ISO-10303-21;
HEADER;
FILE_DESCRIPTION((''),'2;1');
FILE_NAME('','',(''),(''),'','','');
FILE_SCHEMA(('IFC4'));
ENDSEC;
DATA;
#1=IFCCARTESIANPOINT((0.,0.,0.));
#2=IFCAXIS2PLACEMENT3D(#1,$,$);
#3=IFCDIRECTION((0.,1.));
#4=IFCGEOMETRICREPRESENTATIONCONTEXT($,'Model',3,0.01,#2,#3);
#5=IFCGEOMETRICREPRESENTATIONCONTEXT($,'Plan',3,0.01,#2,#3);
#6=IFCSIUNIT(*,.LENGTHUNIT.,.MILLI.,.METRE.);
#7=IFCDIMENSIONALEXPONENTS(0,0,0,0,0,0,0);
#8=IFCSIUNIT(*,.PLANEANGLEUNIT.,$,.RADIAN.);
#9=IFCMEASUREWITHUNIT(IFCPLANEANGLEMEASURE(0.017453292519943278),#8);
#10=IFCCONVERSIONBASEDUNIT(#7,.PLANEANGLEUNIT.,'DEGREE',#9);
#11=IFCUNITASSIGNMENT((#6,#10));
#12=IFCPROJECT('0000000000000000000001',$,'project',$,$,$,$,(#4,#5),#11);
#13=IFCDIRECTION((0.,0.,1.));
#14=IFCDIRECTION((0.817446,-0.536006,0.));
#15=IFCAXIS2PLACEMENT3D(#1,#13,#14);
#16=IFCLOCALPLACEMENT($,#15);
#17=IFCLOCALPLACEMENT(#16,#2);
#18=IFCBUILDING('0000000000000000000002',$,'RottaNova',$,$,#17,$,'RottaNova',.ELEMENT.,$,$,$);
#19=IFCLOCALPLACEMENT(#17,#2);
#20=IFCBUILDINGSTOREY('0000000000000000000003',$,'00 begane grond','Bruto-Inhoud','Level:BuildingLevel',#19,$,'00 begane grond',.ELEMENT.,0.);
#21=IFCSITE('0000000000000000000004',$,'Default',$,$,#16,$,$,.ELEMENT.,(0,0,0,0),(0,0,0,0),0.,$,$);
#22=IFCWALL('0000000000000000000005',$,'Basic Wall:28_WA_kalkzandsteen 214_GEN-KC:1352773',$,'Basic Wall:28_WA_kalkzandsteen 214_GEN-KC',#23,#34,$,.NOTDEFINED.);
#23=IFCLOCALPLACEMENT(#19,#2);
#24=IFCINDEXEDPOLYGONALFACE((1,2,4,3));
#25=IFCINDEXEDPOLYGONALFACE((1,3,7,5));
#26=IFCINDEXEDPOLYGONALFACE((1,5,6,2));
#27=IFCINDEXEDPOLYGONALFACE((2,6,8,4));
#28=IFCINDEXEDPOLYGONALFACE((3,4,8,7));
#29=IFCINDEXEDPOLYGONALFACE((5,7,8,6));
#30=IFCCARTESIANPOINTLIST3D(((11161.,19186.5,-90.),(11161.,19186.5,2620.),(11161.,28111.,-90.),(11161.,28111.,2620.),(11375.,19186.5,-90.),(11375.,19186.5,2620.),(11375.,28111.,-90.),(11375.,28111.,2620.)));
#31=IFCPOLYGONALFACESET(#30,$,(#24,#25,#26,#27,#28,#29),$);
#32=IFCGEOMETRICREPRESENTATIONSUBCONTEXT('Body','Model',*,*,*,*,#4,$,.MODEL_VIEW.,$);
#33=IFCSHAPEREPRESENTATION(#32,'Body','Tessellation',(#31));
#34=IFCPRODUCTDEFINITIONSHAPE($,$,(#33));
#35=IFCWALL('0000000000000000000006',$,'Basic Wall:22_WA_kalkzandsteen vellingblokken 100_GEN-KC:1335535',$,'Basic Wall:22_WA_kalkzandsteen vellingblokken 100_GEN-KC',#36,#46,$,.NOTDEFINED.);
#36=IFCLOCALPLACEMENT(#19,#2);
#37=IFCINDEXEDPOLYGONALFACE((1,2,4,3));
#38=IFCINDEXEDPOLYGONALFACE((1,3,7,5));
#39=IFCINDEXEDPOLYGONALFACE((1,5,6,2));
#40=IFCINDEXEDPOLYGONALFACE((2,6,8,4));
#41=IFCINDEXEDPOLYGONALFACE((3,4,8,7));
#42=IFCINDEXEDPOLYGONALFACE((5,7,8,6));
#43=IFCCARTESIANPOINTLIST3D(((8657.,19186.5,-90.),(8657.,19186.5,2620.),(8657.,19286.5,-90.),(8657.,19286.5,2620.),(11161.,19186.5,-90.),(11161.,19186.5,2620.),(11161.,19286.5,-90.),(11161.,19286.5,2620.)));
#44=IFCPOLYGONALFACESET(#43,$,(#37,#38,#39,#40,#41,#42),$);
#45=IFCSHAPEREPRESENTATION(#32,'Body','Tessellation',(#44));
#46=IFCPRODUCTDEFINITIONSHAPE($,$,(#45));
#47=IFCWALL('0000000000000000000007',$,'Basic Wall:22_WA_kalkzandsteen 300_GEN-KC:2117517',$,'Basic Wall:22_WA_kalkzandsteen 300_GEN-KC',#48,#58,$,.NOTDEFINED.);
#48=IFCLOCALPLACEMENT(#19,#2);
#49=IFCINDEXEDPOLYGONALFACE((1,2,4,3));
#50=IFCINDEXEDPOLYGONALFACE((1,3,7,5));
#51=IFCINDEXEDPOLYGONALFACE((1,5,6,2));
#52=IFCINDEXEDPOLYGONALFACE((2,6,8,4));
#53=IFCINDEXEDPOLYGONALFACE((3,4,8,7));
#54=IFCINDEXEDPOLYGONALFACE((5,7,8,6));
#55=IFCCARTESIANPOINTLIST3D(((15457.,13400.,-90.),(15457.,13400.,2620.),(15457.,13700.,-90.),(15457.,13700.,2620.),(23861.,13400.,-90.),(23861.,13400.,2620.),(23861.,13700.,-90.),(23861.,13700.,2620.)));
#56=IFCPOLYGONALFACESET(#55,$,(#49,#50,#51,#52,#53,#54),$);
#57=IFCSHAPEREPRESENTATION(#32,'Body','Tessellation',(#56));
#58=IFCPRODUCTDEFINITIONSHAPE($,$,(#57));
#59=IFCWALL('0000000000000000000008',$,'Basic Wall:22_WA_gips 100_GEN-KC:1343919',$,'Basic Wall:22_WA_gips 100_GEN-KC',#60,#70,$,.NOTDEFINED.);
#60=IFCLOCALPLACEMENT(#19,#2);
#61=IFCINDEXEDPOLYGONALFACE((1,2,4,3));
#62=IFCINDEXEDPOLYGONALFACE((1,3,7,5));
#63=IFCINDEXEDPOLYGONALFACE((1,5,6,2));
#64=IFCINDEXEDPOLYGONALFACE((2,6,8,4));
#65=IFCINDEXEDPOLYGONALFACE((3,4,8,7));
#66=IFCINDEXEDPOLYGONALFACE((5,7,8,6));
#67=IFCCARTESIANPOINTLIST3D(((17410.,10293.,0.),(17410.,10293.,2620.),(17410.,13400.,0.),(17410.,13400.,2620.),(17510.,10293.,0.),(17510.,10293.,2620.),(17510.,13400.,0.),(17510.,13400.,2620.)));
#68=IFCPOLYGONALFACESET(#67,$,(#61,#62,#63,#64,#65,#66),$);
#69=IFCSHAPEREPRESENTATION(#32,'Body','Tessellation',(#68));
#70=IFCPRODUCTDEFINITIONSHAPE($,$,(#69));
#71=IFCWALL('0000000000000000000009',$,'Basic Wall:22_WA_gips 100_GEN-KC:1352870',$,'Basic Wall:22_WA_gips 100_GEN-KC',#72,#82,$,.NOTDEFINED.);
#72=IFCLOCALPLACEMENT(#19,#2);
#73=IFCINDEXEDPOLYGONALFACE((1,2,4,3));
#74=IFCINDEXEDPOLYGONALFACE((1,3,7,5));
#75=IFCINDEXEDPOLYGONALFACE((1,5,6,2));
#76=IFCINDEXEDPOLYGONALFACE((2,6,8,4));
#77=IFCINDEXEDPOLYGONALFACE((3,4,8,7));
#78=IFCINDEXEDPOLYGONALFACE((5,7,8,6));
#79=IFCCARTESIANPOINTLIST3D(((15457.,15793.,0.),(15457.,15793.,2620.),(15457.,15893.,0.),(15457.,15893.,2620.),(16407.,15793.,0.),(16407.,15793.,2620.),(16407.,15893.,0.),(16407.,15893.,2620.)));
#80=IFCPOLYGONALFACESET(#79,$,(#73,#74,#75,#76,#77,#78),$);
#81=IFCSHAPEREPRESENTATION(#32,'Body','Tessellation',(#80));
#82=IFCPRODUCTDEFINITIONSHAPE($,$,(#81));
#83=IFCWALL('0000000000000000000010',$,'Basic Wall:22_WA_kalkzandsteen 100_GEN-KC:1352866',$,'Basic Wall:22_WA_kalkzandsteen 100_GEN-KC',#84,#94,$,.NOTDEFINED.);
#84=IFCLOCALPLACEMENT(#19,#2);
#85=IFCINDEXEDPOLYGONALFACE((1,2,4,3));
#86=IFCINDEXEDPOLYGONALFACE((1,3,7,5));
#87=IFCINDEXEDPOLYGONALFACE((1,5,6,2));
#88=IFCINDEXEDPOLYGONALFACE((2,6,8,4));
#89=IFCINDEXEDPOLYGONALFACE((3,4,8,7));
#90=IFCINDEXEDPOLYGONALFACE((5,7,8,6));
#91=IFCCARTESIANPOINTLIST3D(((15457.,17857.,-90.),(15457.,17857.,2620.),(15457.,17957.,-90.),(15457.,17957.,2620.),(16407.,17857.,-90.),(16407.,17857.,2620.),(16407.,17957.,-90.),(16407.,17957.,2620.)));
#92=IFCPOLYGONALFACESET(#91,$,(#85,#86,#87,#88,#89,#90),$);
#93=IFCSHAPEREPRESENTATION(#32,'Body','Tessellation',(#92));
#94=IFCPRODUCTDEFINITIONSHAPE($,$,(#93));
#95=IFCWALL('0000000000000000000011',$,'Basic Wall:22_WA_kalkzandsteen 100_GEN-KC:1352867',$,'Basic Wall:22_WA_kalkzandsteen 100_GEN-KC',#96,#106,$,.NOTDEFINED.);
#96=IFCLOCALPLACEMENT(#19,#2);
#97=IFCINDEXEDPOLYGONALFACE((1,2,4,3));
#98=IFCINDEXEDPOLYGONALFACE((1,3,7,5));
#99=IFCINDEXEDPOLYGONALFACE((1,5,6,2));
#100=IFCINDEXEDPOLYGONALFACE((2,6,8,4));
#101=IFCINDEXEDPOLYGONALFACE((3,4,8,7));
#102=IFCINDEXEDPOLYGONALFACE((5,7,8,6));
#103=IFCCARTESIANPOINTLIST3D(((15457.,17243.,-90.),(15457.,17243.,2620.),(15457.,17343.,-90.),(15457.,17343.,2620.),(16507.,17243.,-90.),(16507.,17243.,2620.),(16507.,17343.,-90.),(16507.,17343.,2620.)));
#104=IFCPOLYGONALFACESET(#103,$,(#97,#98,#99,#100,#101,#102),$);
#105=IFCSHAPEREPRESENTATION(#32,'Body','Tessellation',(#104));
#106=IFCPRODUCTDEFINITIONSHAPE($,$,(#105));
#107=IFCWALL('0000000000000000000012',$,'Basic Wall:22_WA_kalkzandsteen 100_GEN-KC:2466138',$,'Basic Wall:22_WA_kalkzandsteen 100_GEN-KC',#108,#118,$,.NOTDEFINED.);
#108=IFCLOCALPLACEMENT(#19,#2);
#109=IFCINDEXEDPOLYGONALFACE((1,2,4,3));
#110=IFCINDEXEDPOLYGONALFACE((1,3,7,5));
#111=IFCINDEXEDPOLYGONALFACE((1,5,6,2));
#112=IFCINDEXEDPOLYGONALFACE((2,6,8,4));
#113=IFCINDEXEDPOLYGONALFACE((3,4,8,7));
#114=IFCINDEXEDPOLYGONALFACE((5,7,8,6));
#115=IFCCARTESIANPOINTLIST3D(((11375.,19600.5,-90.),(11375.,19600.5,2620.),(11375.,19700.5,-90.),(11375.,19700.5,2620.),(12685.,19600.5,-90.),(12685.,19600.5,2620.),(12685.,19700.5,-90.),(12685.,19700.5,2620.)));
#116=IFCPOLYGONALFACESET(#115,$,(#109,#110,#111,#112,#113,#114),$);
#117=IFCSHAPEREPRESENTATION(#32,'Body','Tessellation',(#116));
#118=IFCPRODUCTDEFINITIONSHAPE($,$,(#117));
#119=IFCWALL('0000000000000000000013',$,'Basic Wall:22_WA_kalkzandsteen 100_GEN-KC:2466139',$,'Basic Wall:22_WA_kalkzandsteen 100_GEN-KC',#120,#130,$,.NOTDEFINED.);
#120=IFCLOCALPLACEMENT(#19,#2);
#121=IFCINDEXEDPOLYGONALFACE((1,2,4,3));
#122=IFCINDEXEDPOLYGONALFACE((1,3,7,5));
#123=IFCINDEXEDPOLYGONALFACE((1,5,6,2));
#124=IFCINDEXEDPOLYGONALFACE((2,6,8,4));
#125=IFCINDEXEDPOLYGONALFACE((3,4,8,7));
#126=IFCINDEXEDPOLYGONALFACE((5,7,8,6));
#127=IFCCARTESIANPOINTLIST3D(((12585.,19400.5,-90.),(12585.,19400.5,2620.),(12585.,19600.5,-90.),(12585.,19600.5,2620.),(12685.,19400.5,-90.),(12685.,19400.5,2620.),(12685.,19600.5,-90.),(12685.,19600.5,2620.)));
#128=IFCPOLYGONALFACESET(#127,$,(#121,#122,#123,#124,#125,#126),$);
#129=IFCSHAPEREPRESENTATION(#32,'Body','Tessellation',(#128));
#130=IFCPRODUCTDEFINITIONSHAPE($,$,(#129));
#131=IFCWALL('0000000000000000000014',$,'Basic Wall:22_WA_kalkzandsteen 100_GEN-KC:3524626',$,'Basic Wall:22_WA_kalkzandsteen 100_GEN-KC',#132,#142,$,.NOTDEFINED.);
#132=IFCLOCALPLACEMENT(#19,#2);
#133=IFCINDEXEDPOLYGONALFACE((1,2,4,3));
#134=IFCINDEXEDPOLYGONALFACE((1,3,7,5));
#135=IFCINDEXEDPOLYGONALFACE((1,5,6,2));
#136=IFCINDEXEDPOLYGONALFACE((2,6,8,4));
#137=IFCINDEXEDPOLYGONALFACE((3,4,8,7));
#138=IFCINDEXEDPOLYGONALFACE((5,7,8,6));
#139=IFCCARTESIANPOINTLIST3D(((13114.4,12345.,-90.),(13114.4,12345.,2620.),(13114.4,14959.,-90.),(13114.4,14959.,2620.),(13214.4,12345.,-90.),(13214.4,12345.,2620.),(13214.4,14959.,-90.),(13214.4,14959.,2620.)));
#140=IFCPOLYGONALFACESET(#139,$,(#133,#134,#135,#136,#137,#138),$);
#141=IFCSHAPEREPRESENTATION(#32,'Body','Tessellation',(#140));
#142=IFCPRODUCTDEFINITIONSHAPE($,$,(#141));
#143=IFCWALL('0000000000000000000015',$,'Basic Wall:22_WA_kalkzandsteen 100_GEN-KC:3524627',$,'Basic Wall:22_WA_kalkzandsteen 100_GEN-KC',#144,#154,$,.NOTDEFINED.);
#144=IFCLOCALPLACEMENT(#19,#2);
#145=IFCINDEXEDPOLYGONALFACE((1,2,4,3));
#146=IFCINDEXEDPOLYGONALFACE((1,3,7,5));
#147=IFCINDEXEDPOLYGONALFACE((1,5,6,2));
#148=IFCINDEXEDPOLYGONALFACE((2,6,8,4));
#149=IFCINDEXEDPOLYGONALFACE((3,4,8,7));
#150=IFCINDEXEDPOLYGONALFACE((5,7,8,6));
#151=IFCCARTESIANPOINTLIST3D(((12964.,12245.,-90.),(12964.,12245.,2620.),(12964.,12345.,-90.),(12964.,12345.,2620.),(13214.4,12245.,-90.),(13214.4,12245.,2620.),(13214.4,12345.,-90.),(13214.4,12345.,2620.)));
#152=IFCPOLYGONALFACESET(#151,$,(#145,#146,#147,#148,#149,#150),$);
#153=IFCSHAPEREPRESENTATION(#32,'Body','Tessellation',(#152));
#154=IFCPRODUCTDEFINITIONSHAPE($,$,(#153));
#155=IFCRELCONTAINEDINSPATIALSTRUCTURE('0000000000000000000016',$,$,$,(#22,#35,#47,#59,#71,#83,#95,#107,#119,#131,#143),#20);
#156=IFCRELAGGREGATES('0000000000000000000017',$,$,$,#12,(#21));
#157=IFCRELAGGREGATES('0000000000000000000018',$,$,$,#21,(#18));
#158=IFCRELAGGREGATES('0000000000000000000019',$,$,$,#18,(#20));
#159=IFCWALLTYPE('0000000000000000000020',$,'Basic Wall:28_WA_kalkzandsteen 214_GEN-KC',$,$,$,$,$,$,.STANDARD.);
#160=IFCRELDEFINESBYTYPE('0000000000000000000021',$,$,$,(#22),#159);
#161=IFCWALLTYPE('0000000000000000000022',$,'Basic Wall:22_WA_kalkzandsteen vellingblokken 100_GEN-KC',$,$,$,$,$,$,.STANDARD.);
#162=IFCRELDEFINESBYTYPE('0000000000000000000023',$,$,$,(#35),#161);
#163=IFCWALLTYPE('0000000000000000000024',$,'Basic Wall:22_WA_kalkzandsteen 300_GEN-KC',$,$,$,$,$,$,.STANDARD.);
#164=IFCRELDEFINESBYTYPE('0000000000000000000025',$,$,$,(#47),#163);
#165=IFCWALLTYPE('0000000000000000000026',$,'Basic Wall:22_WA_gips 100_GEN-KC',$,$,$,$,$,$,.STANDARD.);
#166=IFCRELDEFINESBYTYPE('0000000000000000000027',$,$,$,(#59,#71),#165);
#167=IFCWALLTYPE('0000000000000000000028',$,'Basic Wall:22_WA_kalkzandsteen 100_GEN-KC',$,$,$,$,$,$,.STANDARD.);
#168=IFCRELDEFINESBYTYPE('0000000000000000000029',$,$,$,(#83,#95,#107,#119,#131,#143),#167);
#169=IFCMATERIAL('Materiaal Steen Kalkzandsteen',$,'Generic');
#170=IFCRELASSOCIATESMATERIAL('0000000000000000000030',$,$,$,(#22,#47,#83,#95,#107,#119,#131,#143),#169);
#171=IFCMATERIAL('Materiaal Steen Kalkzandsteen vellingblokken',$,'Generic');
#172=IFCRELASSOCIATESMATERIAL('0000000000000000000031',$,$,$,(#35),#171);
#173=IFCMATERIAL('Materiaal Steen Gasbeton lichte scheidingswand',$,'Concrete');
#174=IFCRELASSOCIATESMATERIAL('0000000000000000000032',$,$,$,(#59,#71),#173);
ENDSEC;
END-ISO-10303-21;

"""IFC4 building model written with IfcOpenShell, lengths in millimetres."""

from ifc_helpers import new_model, entity, si_unit, converted_unit, direction, frame, origin, place, context, subcontext, project, spatial, indexed_curve, outline, extrude, material, type_object, element, save


model = new_model("IFC4")

# Units and contexts
model_context = context("Model", 3, precision=0.01, world=origin(), true_north=direction((0.0, 1.0)))
plan_context = context("Plan", 3, precision=0.01, world=origin(), true_north=direction((0.0, 1.0)))
body_context = subcontext(model_context, "Body", "Model", "MODEL_VIEW")
ifc_project = project(units=[si_unit("LENGTHUNIT", "METRE", prefix="MILLI"), converted_unit("PLANEANGLEUNIT", "DEGREE", entity("IfcPlaneAngleMeasure", 0.017453292519943278), si_unit("PLANEANGLEUNIT", "RADIAN"), dimensions=[0, 0, 0, 0, 0, 0, 0])], contexts=[model_context, plan_context])

# Site, building, storey
site_placement = place(None, frame((0.0, 0.0, 0.0), z_axis=(0.0, 0.0, 1.0), x_axis=(0.817446, -0.536006, 0.0)))
site = spatial("IfcSite", under=ifc_project, at=site_placement, Name="Default", CompositionType="ELEMENT", RefLatitude=(0, 0, 0, 0), RefLongitude=(0, 0, 0, 0), RefElevation=0.0)
building_placement = place(site_placement, origin())
building = spatial("IfcBuilding", under=site, at=building_placement, Name="RottaNova", LongName="RottaNova", CompositionType="ELEMENT")
storey_placement = place(building_placement, origin())
storey = spatial("IfcBuildingStorey", under=building, at=storey_placement, Name="00 begane grond", Description="Bruto-Inhoud", ObjectType="Level:BuildingLevel", LongName="00 begane grond", CompositionType="ELEMENT", Elevation=0.0)

# Walls
ifc_material_1 = material(Name="Materiaal Steen Kalkzandsteen", Category="Generic")
wall_type_1 = type_object("IfcWallType", Name="Basic Wall:28_WA_kalkzandsteen 214_GEN-KC", PredefinedType="STANDARD")
wall_1_placement = place(storey_placement, frame((11268.0, 19186.5, -90.0), z_axis=(0.0, 0.0, 1.0), x_axis=(0.0, 1.0, 0.0)))
element("IfcWall", 1, at=wall_1_placement, inside=storey, type_object=wall_type_1, material=ifc_material_1, Name="Basic Wall:28_WA_kalkzandsteen 214_GEN-KC:1352773", ObjectType="Basic Wall:28_WA_kalkzandsteen 214_GEN-KC", PredefinedType="NOTDEFINED", context=body_context, shape_type="SweptSolid", body=[
    extrude(outline(indexed_curve([(8924.5, 107.0), (0.0, 107.0), (0.0, -107.0), (8924.5, -107.0), (8924.5, 107.0)], self_intersect=False)), origin(), (0.0, 0.0, 1.0), 2710.0),
])
ifc_material_2 = material(Name="Materiaal Steen Kalkzandsteen vellingblokken", Category="Generic")
wall_type_2 = type_object("IfcWallType", Name="Basic Wall:22_WA_kalkzandsteen vellingblokken 100_GEN-KC", PredefinedType="STANDARD")
wall_2_placement = place(storey_placement, frame((8657.0, 19236.5, -90.0)))
element("IfcWall", 2, at=wall_2_placement, inside=storey, type_object=wall_type_2, material=ifc_material_2, Name="Basic Wall:22_WA_kalkzandsteen vellingblokken 100_GEN-KC:1335535", ObjectType="Basic Wall:22_WA_kalkzandsteen vellingblokken 100_GEN-KC", PredefinedType="NOTDEFINED", context=body_context, shape_type="SweptSolid", body=[
    extrude(outline(indexed_curve([(2504.0, 50.0), (0.0, 50.0), (0.0, -50.0), (2504.0, -50.0), (2504.0, 50.0)], self_intersect=False)), origin(), (0.0, 0.0, 1.0), 2710.0),
])
wall_type_3 = type_object("IfcWallType", Name="Basic Wall:22_WA_kalkzandsteen 300_GEN-KC", PredefinedType="STANDARD")
wall_3_placement = place(storey_placement, frame((15457.0, 13550.0, -90.0)))
element("IfcWall", 3, at=wall_3_placement, inside=storey, type_object=wall_type_3, material=ifc_material_1, Name="Basic Wall:22_WA_kalkzandsteen 300_GEN-KC:2117517", ObjectType="Basic Wall:22_WA_kalkzandsteen 300_GEN-KC", PredefinedType="NOTDEFINED", context=body_context, shape_type="SweptSolid", body=[
    extrude(outline(indexed_curve([(8404.0, 150.0), (0.0, 150.0), (0.0, -150.0), (8404.0, -150.0), (8404.0, 150.0)], self_intersect=False)), origin(), (0.0, 0.0, 1.0), 2710.0),
])
ifc_material_3 = material(Name="Materiaal Steen Gasbeton lichte scheidingswand", Category="Concrete")
wall_type_4 = type_object("IfcWallType", Name="Basic Wall:22_WA_gips 100_GEN-KC", PredefinedType="STANDARD")
wall_4_placement = place(storey_placement, frame((17460.0, 13400.0, 0.0), z_axis=(0.0, 0.0, 1.0), x_axis=(0.0, -1.0, 0.0)))
element("IfcWall", 4, at=wall_4_placement, inside=storey, type_object=wall_type_4, material=ifc_material_3, Name="Basic Wall:22_WA_gips 100_GEN-KC:1343919", ObjectType="Basic Wall:22_WA_gips 100_GEN-KC", PredefinedType="NOTDEFINED", context=body_context, shape_type="SweptSolid", body=[
    extrude(outline(indexed_curve([(3107.0, 50.0), (0.0, 50.0), (0.0, -50.0), (3107.0, -50.0), (3107.0, 50.0)], self_intersect=False)), origin(), (0.0, 0.0, 1.0), 2620.0),
])
wall_5_placement = place(storey_placement, frame((16407.0, 15843.0, 0.0), z_axis=(0.0, 0.0, 1.0), x_axis=(-1.0, 0.0, 0.0)))
element("IfcWall", 5, at=wall_5_placement, inside=storey, type_object=wall_type_4, material=ifc_material_3, Name="Basic Wall:22_WA_gips 100_GEN-KC:1352870", ObjectType="Basic Wall:22_WA_gips 100_GEN-KC", PredefinedType="NOTDEFINED", context=body_context, shape_type="SweptSolid", body=[
    extrude(outline(indexed_curve([(950.0, 50.0), (0.0, 50.0), (0.0, -50.0), (950.0, -50.0), (950.0, 50.0)], self_intersect=False)), origin(), (0.0, 0.0, 1.0), 2620.0),
])
wall_type_5 = type_object("IfcWallType", Name="Basic Wall:22_WA_kalkzandsteen 100_GEN-KC", PredefinedType="STANDARD")
wall_6_placement = place(storey_placement, frame((16407.0, 17907.0, -90.0), z_axis=(0.0, 0.0, 1.0), x_axis=(-1.0, 0.0, 0.0)))
element("IfcWall", 6, at=wall_6_placement, inside=storey, type_object=wall_type_5, material=ifc_material_1, Name="Basic Wall:22_WA_kalkzandsteen 100_GEN-KC:1352866", ObjectType="Basic Wall:22_WA_kalkzandsteen 100_GEN-KC", PredefinedType="NOTDEFINED", context=body_context, shape_type="SweptSolid", body=[
    extrude(outline(indexed_curve([(950.0, 50.0), (0.0, 50.0), (0.0, -50.0), (950.0, -50.0), (950.0, 50.0)], self_intersect=False)), origin(), (0.0, 0.0, 1.0), 2710.0),
])
wall_7_placement = place(storey_placement, frame((16507.0, 17293.0, -90.0), z_axis=(0.0, 0.0, 1.0), x_axis=(-1.0, 0.0, 0.0)))
element("IfcWall", 7, at=wall_7_placement, inside=storey, type_object=wall_type_5, material=ifc_material_1, Name="Basic Wall:22_WA_kalkzandsteen 100_GEN-KC:1352867", ObjectType="Basic Wall:22_WA_kalkzandsteen 100_GEN-KC", PredefinedType="NOTDEFINED", context=body_context, shape_type="SweptSolid", body=[
    extrude(outline(indexed_curve([(1050.0, 50.0), (0.0, 50.0), (0.0, -50.0), (1050.0, -50.0), (1050.0, 50.0)], self_intersect=False)), origin(), (0.0, 0.0, 1.0), 2710.0),
])
wall_8_placement = place(storey_placement, frame((11375.0, 19650.5, -90.0)))
element("IfcWall", 8, at=wall_8_placement, inside=storey, type_object=wall_type_5, material=ifc_material_1, Name="Basic Wall:22_WA_kalkzandsteen 100_GEN-KC:2466138", ObjectType="Basic Wall:22_WA_kalkzandsteen 100_GEN-KC", PredefinedType="NOTDEFINED", context=body_context, shape_type="SweptSolid", body=[
    extrude(outline(indexed_curve([(1310.0, 50.0), (0.0, 50.0), (0.0, -50.0), (1310.0, -50.0), (1310.0, 50.0)], self_intersect=False)), origin(), (0.0, 0.0, 1.0), 2710.0),
])
wall_9_placement = place(storey_placement, frame((12635.0, 19600.5, -90.0), z_axis=(0.0, 0.0, 1.0), x_axis=(0.0, -1.0, 0.0)))
element("IfcWall", 9, at=wall_9_placement, inside=storey, type_object=wall_type_5, material=ifc_material_1, Name="Basic Wall:22_WA_kalkzandsteen 100_GEN-KC:2466139", ObjectType="Basic Wall:22_WA_kalkzandsteen 100_GEN-KC", PredefinedType="NOTDEFINED", context=body_context, shape_type="SweptSolid", body=[
    extrude(outline(indexed_curve([(200.0, 50.0), (0.0, 50.0), (0.0, -50.0), (200.0, -50.0), (200.0, 50.0)], self_intersect=False)), origin(), (0.0, 0.0, 1.0), 2710.0),
])
wall_10_placement = place(storey_placement, frame((13164.4, 14959.0, -90.0), z_axis=(0.0, 0.0, 1.0), x_axis=(0.0, -1.0, 0.0)))
element("IfcWall", 10, at=wall_10_placement, inside=storey, type_object=wall_type_5, material=ifc_material_1, Name="Basic Wall:22_WA_kalkzandsteen 100_GEN-KC:3524626", ObjectType="Basic Wall:22_WA_kalkzandsteen 100_GEN-KC", PredefinedType="NOTDEFINED", context=body_context, shape_type="SweptSolid", body=[
    extrude(outline(indexed_curve([(2614.0, 50.0), (0.0, 50.0), (0.0, -50.0), (2614.0, -50.0), (2614.0, 50.0)], self_intersect=False)), origin(), (0.0, 0.0, 1.0), 2710.0),
])
wall_11_placement = place(storey_placement, frame((13214.4, 12295.0, -90.0), z_axis=(0.0, 0.0, 1.0), x_axis=(-1.0, 0.0, 0.0)))
element("IfcWall", 11, at=wall_11_placement, inside=storey, type_object=wall_type_5, material=ifc_material_1, Name="Basic Wall:22_WA_kalkzandsteen 100_GEN-KC:3524627", ObjectType="Basic Wall:22_WA_kalkzandsteen 100_GEN-KC", PredefinedType="NOTDEFINED", context=body_context, shape_type="SweptSolid", body=[
    extrude(outline(indexed_curve([(250.4, 50.0), (0.0, 50.0), (0.0, -50.0), (250.4, -50.0), (250.4, 50.0)], self_intersect=False)), origin(), (0.0, 0.0, 1.0), 2710.0),
])

save(model, "model.ifc")
